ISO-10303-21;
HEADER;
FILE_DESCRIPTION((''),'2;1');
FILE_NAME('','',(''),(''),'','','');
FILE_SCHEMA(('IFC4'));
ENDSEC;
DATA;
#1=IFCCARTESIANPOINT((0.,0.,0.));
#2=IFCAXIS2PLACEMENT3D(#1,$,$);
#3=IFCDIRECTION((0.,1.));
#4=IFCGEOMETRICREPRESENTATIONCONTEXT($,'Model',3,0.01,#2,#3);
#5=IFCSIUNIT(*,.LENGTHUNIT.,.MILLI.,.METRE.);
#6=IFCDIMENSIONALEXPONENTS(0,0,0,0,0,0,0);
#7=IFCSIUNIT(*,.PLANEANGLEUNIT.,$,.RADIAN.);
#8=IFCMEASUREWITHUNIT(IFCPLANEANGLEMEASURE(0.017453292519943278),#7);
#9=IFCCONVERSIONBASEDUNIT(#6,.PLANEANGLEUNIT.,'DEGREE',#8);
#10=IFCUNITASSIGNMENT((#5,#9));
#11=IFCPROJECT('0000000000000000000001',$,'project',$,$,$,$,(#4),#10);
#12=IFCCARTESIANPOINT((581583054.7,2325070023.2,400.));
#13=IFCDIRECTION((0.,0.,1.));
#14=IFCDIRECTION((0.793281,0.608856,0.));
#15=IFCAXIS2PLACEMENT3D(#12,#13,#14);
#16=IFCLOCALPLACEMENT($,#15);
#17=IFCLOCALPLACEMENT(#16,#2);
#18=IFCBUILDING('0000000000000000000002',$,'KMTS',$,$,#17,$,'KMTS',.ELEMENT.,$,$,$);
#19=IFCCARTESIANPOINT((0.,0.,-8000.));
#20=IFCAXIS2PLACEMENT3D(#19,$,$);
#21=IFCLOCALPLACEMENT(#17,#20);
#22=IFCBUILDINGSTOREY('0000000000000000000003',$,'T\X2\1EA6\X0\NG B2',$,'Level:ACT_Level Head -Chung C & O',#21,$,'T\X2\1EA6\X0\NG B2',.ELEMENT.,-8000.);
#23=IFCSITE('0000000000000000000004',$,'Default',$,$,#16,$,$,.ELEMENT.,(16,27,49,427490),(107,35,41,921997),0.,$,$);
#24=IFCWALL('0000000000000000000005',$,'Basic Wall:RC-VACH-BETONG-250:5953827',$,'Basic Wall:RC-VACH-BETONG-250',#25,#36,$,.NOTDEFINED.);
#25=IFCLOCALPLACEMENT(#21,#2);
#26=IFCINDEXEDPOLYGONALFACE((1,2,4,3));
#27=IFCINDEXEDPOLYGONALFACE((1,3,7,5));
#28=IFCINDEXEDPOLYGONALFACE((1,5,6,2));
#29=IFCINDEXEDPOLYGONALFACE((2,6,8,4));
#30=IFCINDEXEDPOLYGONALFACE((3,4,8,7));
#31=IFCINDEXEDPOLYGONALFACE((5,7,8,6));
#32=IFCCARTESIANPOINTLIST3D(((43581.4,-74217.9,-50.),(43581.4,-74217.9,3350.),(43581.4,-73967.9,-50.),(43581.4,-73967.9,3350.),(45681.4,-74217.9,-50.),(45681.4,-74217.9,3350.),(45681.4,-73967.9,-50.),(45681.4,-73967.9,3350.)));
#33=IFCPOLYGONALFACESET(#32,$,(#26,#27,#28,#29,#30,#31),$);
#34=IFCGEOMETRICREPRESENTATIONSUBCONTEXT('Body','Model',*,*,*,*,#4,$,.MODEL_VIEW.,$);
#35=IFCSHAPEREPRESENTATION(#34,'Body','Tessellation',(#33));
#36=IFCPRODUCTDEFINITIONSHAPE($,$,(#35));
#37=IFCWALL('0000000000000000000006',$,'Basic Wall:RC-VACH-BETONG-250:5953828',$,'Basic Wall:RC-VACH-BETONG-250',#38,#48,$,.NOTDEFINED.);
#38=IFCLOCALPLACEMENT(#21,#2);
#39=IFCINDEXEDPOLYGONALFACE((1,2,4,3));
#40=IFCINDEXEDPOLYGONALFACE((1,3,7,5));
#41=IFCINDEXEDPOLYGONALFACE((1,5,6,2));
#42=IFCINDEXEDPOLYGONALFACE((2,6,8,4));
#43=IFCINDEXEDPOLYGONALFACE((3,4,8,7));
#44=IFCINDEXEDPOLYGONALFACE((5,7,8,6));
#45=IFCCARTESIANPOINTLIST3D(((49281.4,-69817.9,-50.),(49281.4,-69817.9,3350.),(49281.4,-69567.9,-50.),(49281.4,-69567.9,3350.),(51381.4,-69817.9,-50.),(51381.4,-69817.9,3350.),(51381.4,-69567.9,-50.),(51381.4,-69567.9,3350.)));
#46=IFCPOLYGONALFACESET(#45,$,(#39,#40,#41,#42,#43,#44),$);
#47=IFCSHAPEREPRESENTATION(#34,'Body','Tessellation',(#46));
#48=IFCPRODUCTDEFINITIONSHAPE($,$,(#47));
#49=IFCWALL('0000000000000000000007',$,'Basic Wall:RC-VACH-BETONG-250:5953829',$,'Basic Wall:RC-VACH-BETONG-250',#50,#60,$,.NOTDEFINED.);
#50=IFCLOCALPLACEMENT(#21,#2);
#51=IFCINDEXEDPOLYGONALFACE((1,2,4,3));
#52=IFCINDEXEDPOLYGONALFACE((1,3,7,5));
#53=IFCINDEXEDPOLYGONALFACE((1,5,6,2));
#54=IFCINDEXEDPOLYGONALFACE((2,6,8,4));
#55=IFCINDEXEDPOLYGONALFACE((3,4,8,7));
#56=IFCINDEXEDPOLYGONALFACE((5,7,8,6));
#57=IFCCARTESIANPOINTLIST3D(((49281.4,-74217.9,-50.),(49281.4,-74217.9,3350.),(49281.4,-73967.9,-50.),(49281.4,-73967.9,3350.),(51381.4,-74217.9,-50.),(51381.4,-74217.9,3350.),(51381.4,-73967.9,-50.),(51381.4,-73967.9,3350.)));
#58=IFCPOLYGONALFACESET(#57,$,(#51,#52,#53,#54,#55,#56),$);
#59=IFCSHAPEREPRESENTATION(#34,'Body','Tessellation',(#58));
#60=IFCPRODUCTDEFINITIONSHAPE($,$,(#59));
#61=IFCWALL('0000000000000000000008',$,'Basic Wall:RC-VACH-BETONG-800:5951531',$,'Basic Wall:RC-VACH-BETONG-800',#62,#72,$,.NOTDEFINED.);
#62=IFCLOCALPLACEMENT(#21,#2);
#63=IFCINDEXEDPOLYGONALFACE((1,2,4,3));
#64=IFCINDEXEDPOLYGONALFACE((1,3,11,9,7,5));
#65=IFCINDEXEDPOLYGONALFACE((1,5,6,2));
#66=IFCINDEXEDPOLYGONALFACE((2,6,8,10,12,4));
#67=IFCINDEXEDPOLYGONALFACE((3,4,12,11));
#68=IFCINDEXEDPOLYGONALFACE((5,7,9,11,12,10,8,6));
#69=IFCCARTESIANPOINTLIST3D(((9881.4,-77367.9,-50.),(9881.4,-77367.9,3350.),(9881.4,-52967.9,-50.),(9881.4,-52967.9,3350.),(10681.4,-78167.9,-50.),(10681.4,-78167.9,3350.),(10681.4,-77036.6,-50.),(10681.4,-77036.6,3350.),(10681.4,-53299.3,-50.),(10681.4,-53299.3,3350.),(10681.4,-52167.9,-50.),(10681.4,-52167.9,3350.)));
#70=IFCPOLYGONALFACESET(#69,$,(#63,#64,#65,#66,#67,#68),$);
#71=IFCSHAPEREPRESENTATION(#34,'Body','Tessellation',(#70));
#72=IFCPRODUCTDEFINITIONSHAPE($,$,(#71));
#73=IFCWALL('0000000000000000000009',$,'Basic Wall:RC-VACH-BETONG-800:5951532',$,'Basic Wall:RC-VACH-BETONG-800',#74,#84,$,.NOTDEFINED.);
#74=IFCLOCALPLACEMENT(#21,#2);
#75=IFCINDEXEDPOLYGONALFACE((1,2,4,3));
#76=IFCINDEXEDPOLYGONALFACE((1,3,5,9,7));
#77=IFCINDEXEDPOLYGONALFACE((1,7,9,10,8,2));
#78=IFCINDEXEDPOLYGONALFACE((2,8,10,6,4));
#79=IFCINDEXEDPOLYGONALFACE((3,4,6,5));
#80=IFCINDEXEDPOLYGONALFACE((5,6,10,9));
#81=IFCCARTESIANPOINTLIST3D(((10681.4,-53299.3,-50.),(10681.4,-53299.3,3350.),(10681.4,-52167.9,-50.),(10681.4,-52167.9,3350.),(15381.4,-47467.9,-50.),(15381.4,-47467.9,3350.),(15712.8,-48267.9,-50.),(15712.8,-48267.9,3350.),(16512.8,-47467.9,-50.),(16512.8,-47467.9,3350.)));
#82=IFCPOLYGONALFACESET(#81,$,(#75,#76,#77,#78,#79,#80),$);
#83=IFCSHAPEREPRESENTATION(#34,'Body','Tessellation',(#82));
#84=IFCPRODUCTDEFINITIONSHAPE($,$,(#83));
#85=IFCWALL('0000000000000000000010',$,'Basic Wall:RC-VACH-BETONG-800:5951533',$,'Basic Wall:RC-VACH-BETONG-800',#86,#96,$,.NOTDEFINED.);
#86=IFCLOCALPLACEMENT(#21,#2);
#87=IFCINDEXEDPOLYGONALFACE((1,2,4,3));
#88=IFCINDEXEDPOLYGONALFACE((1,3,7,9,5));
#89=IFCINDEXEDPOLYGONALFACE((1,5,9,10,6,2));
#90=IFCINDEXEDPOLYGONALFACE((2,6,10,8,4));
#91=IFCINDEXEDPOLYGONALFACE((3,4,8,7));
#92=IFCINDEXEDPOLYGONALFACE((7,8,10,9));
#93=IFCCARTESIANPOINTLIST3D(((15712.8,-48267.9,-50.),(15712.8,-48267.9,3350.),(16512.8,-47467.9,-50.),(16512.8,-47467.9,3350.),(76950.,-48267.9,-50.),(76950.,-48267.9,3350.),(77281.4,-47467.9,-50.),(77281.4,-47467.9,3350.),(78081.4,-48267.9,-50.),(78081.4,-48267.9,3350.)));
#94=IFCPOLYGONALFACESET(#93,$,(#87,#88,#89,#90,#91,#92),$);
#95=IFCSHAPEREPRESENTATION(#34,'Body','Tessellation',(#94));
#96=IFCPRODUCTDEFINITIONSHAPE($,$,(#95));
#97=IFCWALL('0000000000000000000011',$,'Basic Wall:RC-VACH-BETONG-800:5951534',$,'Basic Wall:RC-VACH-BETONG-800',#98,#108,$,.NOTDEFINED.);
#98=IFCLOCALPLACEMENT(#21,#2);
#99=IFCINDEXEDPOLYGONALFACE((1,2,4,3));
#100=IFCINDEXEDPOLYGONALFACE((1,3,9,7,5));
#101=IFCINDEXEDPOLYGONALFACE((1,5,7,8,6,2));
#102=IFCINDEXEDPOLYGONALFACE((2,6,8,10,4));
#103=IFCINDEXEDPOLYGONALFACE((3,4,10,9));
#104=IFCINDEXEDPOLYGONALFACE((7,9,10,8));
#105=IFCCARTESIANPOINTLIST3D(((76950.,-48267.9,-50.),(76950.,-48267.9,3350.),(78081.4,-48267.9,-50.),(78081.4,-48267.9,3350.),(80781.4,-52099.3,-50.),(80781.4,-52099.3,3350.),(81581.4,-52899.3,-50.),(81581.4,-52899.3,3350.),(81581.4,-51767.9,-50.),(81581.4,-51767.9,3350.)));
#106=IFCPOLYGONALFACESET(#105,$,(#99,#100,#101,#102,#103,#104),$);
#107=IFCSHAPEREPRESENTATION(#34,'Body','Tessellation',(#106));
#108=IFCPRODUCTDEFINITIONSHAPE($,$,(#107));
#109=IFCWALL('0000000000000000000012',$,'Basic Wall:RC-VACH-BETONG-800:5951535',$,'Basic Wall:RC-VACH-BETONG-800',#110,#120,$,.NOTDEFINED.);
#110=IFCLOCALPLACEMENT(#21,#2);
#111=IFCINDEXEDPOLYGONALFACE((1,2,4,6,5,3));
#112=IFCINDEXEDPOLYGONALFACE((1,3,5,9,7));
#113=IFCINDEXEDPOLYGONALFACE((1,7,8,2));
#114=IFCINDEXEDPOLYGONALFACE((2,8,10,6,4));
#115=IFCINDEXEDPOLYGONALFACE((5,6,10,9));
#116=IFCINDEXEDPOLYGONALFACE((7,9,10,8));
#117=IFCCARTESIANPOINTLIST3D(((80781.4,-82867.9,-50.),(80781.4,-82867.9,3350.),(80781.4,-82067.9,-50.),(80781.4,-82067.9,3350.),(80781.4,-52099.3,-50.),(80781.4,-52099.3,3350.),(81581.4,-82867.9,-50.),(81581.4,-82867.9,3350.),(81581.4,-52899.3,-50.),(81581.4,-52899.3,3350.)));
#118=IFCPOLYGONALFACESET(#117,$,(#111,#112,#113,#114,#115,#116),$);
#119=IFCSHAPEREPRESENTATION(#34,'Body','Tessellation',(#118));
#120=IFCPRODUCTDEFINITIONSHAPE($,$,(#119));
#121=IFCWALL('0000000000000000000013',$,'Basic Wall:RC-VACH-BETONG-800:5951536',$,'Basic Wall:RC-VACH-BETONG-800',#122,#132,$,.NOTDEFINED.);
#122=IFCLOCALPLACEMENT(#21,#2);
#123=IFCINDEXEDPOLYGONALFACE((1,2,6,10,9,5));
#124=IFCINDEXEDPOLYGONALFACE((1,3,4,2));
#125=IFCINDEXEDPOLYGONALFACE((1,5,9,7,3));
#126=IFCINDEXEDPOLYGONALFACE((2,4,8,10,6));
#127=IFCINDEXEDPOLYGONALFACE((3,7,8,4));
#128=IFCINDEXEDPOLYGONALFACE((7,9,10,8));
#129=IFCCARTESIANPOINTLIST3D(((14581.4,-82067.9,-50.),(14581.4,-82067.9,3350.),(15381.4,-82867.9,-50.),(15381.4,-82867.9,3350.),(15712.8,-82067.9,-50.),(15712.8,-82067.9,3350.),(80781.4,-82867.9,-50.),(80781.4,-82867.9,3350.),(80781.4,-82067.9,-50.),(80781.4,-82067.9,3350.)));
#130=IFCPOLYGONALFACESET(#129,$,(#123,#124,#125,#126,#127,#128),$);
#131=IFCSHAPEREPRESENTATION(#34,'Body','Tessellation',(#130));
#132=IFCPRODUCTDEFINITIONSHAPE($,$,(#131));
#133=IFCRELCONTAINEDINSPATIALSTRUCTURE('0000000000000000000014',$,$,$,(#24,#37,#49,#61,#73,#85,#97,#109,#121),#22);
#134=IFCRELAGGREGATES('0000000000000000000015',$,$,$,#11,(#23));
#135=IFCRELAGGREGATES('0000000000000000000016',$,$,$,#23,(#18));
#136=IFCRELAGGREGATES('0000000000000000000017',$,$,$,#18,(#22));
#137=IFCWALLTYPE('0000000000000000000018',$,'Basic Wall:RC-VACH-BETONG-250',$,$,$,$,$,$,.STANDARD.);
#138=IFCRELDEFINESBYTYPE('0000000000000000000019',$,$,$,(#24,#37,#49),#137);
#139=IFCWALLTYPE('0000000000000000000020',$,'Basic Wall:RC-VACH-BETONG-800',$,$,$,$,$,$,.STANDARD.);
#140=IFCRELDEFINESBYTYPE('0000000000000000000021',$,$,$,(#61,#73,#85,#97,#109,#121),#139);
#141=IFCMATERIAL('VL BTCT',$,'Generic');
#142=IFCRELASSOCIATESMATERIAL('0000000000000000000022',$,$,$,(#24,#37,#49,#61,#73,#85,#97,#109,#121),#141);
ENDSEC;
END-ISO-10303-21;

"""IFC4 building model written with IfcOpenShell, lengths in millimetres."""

from ifc_helpers import new_model, entity, si_unit, converted_unit, direction, frame, origin, place, context, subcontext, project, spatial, indexed_curve, outline, extrude, material, type_object, element, save


model = new_model("IFC4")

# Units and contexts
model_context = context("Model", 3, precision=0.01, world=origin(), true_north=direction((0.0, 1.0)))
body_context = subcontext(model_context, "Body", "Model", "MODEL_VIEW")
ifc_project = project(units=[si_unit("LENGTHUNIT", "METRE", prefix="MILLI"), converted_unit("PLANEANGLEUNIT", "DEGREE", entity("IfcPlaneAngleMeasure", 0.017453292519943278), si_unit("PLANEANGLEUNIT", "RADIAN"), dimensions=[0, 0, 0, 0, 0, 0, 0])], contexts=[model_context])

# Site, building, storey
site_placement = place(None, frame((581583054.7, 2325070023.2, 400.0), z_axis=(0.0, 0.0, 1.0), x_axis=(0.793281, 0.608856, 0.0)))
site = spatial("IfcSite", under=ifc_project, at=site_placement, Name="Default", CompositionType="ELEMENT", RefLatitude=(16, 27, 49, 427490), RefLongitude=(107, 35, 41, 921997), RefElevation=0.0)
building_placement = place(site_placement, origin())
building = spatial("IfcBuilding", under=site, at=building_placement, Name="KMTS", LongName="KMTS", CompositionType="ELEMENT")
storey_placement = place(building_placement, frame((0.0, 0.0, -8000.0)))
storey = spatial("IfcBuildingStorey", under=building, at=storey_placement, Name="TẦNG B2", ObjectType="Level:ACT_Level Head -Chung C & O", LongName="TẦNG B2", CompositionType="ELEMENT", Elevation=-8000.0)

# Shared definitions
ifc_material = material(Name="VL BTCT", Category="Generic")

# Walls
wall_type_1 = type_object("IfcWallType", Name="Basic Wall:RC-VACH-BETONG-250", PredefinedType="STANDARD")
wall_1_placement = place(storey_placement, frame((45681.4, -74092.9, -50.0), z_axis=(0.0, 0.0, 1.0), x_axis=(-1.0, 0.0, 0.0)))
element("IfcWall", 1, at=wall_1_placement, inside=storey, type_object=wall_type_1, material=ifc_material, Name="Basic Wall:RC-VACH-BETONG-250:5953827", ObjectType="Basic Wall:RC-VACH-BETONG-250", PredefinedType="NOTDEFINED", context=body_context, shape_type="SweptSolid", body=[
    extrude(outline(indexed_curve([(2100.0, 125.0), (0.0, 125.0), (0.0, -125.0), (2100.0, -125.0), (2100.0, 125.0)], self_intersect=False)), origin(), (0.0, 0.0, 1.0), 3400.0),
])
for number, where, z_axis, x_axis, name in (
    (2, (51381.4, -69692.9, -50.0), (0.0, 0.0, 1.0), (-1.0, 0.0, 0.0), "Basic Wall:RC-VACH-BETONG-250:5953828"),
    (3, (51381.4, -74092.9, -50.0), (0.0, 0.0, 1.0), (-1.0, 0.0, 0.0), "Basic Wall:RC-VACH-BETONG-250:5953829"),
):
    element("IfcWall", number, at=place(storey_placement, frame(where, z_axis=z_axis, x_axis=x_axis)), inside=storey, type_object=wall_type_1, material=ifc_material, Name=name, ObjectType="Basic Wall:RC-VACH-BETONG-250", PredefinedType="NOTDEFINED", context=body_context, shape_type="SweptSolid", body=[
        extrude(outline(indexed_curve([(2100.0, 125.0), (0.0, 125.0), (0.0, -125.0), (2100.0, -125.0), (2100.0, 125.0)], self_intersect=False)), origin(), (0.0, 0.0, 1.0), 3400.0),
    ])
wall_type_2 = type_object("IfcWallType", Name="Basic Wall:RC-VACH-BETONG-800", PredefinedType="STANDARD")
wall_2_placement = place(storey_placement, frame((10281.4, -78167.9, -50.0), z_axis=(0.0, 0.0, 1.0), x_axis=(0.0, 1.0, 0.0)))
element("IfcWall", 4, at=wall_2_placement, inside=storey, type_object=wall_type_2, material=ifc_material, Name="Basic Wall:RC-VACH-BETONG-800:5951531", ObjectType="Basic Wall:RC-VACH-BETONG-800", PredefinedType="NOTDEFINED", context=body_context, shape_type="SweptSolid", body=[
    extrude(outline(indexed_curve([(26000.0, -400.0), (25200.0, 400.0), (800.0, 400.0), (0.0, -400.0), (1131.4, -400.0), (24868.6, -400.0), (26000.0, -400.0)], self_intersect=False)), origin(), (0.0, 0.0, 1.0), 3400.0),
])
wall_3_placement = place(storey_placement, frame((10398.5, -53016.5, -50.0), z_axis=(0.0, 0.0, 1.0), x_axis=(0.707107, 0.707107, 0.0)))
element("IfcWall", 5, at=wall_3_placement, inside=storey, type_object=wall_type_2, material=ifc_material, Name="Basic Wall:RC-VACH-BETONG-800:5951532", ObjectType="Basic Wall:RC-VACH-BETONG-800", PredefinedType="NOTDEFINED", context=body_context, shape_type="SweptSolid", body=[
    extrude(outline(indexed_curve([(8246.8, -400.0), (7446.8, 400.0), (800.0, 400.0), (0.0, -400.0), (7115.4, -400.0), (8246.8, -400.0)], self_intersect=False)), origin(), (0.0, 0.0, 1.0), 3400.0),
])
wall_4_placement = place(storey_placement, frame((15712.8, -47867.9, -50.0)))
element("IfcWall", 6, at=wall_4_placement, inside=storey, type_object=wall_type_2, material=ifc_material, Name="Basic Wall:RC-VACH-BETONG-800:5951533", ObjectType="Basic Wall:RC-VACH-BETONG-800", PredefinedType="NOTDEFINED", context=body_context, shape_type="SweptSolid", body=[
    extrude(outline(indexed_curve([(62368.6, -400.0), (61568.6, 400.0), (800.0, 400.0), (0.0, -400.0), (61237.3, -400.0), (62368.6, -400.0)], self_intersect=False)), origin(), (0.0, 0.0, 1.0), 3400.0),
])
wall_5_placement = place(storey_placement, frame((77232.9, -47985.1, -50.0), z_axis=(0.0, 0.0, 1.0), x_axis=(0.707107, -0.707107, 0.0)))
element("IfcWall", 7, at=wall_5_placement, inside=storey, type_object=wall_type_2, material=ifc_material, Name="Basic Wall:RC-VACH-BETONG-800:5951534", ObjectType="Basic Wall:RC-VACH-BETONG-800", PredefinedType="NOTDEFINED", context=body_context, shape_type="SweptSolid", body=[
    extrude(outline(indexed_curve([(6549.7, -400.0), (5749.7, 400.0), (800.0, 400.0), (0.0, -400.0), (5418.4, -400.0), (6549.7, -400.0)], self_intersect=False)), origin(), (0.0, 0.0, 1.0), 3400.0),
])
wall_6_placement = place(storey_placement, frame((81181.4, -52099.3, -50.0), z_axis=(0.0, 0.0, 1.0), x_axis=(0.0, -1.0, 0.0)))
element("IfcWall", 8, at=wall_6_placement, inside=storey, type_object=wall_type_2, material=ifc_material, Name="Basic Wall:RC-VACH-BETONG-800:5951535", ObjectType="Basic Wall:RC-VACH-BETONG-800", PredefinedType="NOTDEFINED", context=body_context, shape_type="SweptSolid", body=[
    extrude(outline(indexed_curve([(30768.6, -400.0), (30768.6, 400.0), (800.0, 400.0), (0.0, -400.0), (29968.6, -400.0), (30768.6, -400.0)], self_intersect=False)), origin(), (0.0, 0.0, 1.0), 3400.0),
])
wall_7_placement = place(storey_placement, frame((80781.4, -82467.9, -50.0), z_axis=(0.0, 0.0, 1.0), x_axis=(-1.0, 0.0, 0.0)))
element("IfcWall", 9, at=wall_7_placement, inside=storey, type_object=wall_type_2, material=ifc_material, Name="Basic Wall:RC-VACH-BETONG-800:5951536", ObjectType="Basic Wall:RC-VACH-BETONG-800", PredefinedType="NOTDEFINED", context=body_context, shape_type="SweptSolid", body=[
    extrude(outline(indexed_curve([(66200.0, -400.0), (65400.0, 400.0), (0.0, 400.0), (0.0, -400.0), (65068.6, -400.0), (66200.0, -400.0)], self_intersect=False)), origin(), (0.0, 0.0, 1.0), 3400.0),
])

save(model, "model.ifc")
